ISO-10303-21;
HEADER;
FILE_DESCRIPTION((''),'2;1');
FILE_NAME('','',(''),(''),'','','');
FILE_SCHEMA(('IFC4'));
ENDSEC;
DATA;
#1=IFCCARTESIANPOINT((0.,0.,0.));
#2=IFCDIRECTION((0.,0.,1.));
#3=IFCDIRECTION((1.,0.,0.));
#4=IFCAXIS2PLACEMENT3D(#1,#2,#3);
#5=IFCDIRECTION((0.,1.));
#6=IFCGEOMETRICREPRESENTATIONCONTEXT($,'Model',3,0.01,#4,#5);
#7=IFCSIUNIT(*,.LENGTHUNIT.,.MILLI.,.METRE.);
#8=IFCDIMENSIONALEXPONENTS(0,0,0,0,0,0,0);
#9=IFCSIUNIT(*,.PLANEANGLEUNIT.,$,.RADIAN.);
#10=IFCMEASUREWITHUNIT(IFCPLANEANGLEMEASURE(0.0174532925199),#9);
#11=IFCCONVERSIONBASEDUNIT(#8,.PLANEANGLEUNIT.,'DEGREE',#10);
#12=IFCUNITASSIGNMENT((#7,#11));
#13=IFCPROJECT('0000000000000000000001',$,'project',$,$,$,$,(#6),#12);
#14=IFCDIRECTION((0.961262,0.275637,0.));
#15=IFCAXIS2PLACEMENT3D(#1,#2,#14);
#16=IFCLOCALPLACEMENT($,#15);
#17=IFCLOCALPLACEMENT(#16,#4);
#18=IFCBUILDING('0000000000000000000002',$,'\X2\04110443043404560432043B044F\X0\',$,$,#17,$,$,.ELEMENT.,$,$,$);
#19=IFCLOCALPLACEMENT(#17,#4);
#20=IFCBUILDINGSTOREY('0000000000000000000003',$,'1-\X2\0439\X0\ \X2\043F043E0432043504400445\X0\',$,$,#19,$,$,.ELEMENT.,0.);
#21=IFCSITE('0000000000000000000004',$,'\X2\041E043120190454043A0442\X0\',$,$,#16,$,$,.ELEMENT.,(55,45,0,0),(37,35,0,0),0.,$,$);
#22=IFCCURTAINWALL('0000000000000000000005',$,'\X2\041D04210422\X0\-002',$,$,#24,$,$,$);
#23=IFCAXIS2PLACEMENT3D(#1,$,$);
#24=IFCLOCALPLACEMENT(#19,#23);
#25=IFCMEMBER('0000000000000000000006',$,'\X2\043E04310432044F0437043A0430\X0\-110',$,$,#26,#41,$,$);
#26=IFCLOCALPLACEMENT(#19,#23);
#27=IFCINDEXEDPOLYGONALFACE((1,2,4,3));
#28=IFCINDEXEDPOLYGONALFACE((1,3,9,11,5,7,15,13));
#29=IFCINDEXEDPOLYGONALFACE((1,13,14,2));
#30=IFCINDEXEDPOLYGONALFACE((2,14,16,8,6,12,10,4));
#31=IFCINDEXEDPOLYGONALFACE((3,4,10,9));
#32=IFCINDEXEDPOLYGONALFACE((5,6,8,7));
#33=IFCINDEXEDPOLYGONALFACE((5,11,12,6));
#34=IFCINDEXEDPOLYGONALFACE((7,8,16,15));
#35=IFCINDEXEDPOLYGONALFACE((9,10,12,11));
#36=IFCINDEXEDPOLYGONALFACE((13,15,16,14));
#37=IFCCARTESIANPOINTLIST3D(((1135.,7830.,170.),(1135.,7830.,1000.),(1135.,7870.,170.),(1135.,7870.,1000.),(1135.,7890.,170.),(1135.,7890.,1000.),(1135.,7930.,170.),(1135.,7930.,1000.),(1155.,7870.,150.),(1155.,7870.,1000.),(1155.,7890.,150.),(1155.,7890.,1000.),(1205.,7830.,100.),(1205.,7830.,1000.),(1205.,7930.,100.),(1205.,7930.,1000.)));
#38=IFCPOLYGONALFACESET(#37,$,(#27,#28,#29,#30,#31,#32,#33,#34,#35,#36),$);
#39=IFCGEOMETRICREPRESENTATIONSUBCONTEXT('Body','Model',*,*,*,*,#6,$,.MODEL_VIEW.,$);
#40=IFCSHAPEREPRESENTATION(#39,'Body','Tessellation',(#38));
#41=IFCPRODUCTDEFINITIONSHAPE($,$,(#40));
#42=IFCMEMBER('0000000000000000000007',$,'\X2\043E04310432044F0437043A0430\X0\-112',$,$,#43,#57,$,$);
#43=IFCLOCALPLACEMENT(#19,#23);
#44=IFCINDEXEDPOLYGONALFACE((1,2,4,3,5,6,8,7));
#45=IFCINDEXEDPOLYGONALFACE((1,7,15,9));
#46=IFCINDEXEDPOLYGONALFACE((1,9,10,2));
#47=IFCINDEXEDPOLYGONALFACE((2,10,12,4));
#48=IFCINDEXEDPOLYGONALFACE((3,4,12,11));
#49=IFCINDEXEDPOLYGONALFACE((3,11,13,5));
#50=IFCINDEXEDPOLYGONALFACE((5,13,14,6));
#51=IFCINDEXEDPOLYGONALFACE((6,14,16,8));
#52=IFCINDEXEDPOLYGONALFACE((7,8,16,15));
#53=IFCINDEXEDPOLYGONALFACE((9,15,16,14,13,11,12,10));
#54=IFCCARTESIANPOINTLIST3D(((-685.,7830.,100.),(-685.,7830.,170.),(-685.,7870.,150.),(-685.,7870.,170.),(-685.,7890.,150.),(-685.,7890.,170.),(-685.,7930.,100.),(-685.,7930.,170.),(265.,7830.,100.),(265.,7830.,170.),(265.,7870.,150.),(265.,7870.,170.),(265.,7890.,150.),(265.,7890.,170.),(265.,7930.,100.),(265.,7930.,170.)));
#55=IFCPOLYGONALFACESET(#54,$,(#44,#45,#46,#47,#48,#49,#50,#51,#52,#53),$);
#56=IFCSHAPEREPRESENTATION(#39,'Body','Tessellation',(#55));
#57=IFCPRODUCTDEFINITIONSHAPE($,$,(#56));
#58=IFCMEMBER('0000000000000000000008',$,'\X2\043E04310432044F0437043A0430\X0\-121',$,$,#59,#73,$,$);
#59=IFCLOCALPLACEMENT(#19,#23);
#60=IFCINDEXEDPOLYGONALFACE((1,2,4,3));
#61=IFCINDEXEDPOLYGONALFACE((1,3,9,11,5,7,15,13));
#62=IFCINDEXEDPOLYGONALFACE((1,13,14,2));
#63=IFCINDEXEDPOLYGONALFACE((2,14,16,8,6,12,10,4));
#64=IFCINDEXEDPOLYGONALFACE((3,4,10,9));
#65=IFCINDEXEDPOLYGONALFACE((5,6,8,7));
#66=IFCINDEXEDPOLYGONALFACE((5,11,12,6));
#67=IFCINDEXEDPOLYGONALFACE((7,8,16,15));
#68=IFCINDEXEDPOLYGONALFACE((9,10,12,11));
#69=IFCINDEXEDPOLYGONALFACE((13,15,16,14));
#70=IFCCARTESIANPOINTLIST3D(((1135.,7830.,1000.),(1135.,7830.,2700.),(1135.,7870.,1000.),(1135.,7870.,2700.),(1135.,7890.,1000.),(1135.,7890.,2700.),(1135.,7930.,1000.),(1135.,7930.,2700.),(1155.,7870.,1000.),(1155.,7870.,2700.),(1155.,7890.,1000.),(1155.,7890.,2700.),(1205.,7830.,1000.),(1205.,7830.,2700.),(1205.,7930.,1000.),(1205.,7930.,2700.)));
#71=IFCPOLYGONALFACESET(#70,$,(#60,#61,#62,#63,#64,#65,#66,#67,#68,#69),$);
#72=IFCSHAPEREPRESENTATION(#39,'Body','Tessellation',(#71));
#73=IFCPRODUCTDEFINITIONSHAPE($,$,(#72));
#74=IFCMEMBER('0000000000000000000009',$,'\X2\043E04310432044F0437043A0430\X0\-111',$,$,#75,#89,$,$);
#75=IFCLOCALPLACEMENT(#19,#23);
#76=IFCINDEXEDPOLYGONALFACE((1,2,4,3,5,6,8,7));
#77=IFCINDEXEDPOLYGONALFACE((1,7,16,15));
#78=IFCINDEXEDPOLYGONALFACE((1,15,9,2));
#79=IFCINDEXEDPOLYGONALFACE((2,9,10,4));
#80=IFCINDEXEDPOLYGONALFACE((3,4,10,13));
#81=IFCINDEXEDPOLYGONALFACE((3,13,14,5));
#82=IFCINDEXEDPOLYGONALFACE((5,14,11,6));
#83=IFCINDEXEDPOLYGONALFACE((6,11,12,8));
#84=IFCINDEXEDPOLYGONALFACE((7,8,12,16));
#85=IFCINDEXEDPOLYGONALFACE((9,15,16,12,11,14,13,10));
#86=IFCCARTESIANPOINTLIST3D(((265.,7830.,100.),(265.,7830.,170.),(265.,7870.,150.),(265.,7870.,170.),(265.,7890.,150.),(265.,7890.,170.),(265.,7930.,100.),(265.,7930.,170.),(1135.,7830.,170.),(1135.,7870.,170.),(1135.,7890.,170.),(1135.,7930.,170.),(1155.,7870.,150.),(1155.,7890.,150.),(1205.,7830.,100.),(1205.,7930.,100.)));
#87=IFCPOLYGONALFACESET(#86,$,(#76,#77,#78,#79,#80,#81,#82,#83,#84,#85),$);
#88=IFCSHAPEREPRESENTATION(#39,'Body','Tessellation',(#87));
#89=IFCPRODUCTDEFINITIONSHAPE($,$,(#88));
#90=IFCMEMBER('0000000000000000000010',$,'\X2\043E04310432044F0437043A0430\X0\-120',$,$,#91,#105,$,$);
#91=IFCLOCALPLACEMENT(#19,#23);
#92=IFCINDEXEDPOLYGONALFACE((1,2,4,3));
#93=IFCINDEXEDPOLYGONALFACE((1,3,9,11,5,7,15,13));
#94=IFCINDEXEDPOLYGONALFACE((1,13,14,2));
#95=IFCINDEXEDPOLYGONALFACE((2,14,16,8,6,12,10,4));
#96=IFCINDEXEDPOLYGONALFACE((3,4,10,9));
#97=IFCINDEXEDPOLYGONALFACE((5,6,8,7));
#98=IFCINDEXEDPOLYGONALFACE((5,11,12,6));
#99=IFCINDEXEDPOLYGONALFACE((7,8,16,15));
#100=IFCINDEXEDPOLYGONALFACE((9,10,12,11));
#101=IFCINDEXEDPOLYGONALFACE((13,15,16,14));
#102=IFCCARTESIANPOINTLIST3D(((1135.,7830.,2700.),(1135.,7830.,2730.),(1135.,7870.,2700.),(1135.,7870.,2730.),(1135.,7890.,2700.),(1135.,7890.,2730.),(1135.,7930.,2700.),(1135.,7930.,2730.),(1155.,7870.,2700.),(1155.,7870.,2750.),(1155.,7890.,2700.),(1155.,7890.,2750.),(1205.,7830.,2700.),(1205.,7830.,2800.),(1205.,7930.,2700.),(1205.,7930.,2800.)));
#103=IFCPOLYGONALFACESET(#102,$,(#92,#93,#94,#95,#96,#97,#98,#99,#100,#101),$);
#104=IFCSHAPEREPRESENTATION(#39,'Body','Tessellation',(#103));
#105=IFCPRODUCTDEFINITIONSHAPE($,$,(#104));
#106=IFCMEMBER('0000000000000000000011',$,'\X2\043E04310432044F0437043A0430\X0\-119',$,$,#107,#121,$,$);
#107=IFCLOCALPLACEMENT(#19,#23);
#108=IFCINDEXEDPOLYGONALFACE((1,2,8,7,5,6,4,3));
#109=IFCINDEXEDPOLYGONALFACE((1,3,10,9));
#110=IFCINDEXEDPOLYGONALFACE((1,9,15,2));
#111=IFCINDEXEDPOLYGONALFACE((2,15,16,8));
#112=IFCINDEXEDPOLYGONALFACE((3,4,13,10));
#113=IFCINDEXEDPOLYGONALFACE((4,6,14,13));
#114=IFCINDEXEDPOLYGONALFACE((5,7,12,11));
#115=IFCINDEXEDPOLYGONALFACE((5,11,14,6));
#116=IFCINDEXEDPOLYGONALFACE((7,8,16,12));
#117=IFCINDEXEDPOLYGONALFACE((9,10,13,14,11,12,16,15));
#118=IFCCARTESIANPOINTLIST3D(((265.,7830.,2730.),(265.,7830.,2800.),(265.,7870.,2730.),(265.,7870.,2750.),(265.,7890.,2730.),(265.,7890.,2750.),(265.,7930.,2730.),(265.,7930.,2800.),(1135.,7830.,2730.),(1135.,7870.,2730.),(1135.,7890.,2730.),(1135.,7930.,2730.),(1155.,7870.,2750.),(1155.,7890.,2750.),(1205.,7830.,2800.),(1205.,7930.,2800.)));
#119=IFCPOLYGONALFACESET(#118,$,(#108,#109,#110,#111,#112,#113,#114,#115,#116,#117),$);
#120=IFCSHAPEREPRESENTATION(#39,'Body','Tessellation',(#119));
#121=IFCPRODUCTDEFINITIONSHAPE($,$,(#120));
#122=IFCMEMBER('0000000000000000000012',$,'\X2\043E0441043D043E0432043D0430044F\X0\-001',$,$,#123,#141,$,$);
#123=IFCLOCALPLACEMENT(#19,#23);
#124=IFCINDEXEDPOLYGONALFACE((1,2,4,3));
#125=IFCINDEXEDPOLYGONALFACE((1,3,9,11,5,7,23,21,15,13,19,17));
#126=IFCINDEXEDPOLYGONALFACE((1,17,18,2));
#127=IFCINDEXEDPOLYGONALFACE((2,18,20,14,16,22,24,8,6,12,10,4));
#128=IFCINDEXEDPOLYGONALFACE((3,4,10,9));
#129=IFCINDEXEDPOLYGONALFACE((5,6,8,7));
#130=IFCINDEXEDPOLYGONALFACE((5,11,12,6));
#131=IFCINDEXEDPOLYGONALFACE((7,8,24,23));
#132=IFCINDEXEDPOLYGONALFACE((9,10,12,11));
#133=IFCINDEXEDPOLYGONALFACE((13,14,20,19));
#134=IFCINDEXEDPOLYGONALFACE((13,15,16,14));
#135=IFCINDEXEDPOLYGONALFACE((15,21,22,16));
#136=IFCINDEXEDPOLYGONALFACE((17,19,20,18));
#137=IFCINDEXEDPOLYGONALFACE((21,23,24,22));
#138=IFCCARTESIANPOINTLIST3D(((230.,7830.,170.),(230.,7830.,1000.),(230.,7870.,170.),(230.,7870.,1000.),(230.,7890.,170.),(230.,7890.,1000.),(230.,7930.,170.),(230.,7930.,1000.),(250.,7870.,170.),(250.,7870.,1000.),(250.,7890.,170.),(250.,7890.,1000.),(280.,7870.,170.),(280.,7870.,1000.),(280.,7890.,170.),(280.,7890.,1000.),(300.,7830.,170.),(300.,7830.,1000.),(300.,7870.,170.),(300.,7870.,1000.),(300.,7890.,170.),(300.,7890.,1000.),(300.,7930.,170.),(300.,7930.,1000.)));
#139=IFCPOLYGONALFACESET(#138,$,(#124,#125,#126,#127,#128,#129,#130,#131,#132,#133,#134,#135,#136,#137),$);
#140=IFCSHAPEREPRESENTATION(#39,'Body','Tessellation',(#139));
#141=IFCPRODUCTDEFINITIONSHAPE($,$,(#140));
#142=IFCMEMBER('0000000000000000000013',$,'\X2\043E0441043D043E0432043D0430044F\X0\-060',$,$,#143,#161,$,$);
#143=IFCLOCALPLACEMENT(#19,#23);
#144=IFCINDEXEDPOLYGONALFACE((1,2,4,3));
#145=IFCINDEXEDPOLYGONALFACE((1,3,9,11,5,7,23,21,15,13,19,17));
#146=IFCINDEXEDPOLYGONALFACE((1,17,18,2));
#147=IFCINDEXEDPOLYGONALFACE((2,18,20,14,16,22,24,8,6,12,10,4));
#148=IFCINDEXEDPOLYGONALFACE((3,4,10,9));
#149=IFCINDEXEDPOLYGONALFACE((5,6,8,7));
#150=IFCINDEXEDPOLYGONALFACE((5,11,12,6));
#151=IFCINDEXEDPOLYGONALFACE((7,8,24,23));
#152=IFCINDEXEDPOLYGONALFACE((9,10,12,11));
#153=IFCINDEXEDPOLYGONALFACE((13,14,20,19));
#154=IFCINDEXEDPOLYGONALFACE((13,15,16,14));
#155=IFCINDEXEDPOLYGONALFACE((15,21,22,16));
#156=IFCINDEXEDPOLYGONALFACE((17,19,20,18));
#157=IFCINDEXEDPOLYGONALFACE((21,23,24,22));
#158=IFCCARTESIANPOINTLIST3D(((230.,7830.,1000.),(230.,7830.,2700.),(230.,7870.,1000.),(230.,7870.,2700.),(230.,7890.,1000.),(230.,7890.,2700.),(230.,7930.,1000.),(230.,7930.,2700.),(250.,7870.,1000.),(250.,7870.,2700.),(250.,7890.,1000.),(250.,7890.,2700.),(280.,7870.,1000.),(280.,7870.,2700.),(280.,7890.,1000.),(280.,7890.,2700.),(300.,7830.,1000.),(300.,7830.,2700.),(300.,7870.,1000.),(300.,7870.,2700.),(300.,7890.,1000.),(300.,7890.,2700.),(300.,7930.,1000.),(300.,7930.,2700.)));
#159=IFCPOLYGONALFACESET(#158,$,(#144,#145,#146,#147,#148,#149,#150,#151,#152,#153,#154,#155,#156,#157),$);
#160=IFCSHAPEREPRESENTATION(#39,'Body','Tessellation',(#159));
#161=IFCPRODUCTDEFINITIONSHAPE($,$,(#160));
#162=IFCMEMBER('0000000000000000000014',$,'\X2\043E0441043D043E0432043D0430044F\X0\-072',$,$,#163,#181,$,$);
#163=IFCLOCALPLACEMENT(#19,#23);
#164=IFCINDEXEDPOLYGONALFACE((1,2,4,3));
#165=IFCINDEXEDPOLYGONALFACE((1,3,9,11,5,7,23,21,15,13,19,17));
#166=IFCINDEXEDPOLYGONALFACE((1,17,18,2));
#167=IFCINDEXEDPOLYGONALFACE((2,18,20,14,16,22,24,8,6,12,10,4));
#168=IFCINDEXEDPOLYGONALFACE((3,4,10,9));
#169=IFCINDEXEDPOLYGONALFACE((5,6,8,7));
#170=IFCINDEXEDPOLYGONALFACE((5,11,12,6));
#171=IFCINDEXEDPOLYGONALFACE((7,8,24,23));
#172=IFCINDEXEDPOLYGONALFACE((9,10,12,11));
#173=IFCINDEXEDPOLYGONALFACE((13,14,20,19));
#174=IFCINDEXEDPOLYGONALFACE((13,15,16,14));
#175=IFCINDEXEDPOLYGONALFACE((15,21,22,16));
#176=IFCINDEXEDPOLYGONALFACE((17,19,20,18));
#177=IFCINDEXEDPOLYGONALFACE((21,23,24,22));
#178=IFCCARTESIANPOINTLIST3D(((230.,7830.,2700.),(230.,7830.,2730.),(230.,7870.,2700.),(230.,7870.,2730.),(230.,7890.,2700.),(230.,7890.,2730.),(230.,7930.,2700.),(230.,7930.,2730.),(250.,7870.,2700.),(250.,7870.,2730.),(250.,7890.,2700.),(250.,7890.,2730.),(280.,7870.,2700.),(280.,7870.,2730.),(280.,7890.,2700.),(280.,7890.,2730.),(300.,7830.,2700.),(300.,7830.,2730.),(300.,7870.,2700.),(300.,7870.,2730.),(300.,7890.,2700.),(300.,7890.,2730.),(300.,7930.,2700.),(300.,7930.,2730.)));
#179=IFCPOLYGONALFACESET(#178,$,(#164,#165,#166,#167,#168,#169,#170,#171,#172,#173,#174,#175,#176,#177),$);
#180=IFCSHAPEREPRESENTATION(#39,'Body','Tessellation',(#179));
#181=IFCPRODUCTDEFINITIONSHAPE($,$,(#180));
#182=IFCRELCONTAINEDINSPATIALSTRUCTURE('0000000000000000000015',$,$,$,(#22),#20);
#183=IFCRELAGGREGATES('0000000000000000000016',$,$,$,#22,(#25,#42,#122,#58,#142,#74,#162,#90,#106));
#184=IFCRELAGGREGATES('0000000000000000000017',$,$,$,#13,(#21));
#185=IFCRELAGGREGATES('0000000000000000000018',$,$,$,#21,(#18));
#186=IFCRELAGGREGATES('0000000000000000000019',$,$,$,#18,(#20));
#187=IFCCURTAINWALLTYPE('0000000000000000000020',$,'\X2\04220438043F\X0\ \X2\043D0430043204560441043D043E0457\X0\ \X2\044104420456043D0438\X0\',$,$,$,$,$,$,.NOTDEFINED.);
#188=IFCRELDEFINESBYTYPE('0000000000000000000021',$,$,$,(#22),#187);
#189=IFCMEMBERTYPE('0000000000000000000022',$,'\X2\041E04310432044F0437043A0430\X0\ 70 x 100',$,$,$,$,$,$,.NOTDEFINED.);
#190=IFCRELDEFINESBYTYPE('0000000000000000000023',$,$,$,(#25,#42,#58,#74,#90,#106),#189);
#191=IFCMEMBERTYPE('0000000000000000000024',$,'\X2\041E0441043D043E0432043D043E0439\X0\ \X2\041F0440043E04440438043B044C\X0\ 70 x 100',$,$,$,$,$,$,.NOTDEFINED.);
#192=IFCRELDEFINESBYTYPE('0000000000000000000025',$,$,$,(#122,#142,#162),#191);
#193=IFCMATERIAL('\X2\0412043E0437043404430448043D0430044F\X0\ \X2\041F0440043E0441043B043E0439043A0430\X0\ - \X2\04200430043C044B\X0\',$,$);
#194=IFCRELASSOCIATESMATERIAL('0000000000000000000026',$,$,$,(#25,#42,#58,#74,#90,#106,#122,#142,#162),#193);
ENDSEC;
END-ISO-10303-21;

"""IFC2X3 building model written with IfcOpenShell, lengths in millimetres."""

from ifc_helpers import new_model, entity, si_unit, converted_unit, direction, frame, origin_with_axes, place, context, subcontext, project, spatial, polyline, outline, extrude, clip, halfspace, material, type_object, element, aggregate, save


model = new_model("IFC2X3")

# Units and contexts
model_context = context("Model", 3, precision=0.01, world=origin_with_axes(), true_north=direction((0.0, 1.0)))
body_context = subcontext(model_context, "Body", "Model", "MODEL_VIEW")
ifc_project = project(units=[si_unit("LENGTHUNIT", "METRE", prefix="MILLI"), converted_unit("PLANEANGLEUNIT", "DEGREE", entity("IfcPlaneAngleMeasure", 0.0174532925199), si_unit("PLANEANGLEUNIT", "RADIAN"), dimensions=[0, 0, 0, 0, 0, 0, 0])], contexts=[model_context])

# Site, building, storey
site_placement = place(None, frame((0.0, 0.0, 0.0), z_axis=(0.0, 0.0, 1.0), x_axis=(0.961262, 0.275637, 0.0)))
site = spatial("IfcSite", under=ifc_project, at=site_placement, Name="Об’єкт", CompositionType="ELEMENT", RefLatitude=(55, 45, 0, 0), RefLongitude=(37, 35, 0, 0), RefElevation=0.0)
building_placement = place(site_placement, origin_with_axes())
building = spatial("IfcBuilding", under=site, at=building_placement, Name="Будівля", CompositionType="ELEMENT")
storey_placement = place(building_placement, origin_with_axes())
storey = spatial("IfcBuildingStorey", under=building, at=storey_placement, Name="1-й поверх", CompositionType="ELEMENT", Elevation=0.0)

# Curtain wall, members
curtain_wall_type = type_object("IfcCurtainWallType", Name="Тип навісної стіни", PredefinedType="NOTDEFINED")
curtain_wall_placement = place(storey_placement, frame((-210.0, 7880.0, 100.0), z_axis=(0.0, 0.0, 1.0), x_axis=(1.0, 0.0, 0.0)))
curtain_wall = element("IfcCurtainWall", 1, at=curtain_wall_placement, inside=storey, type_object=curtain_wall_type, Name="НСТ-002")
ifc_material_1 = material(Name="Воздушная Прослойка - Рамы")
member_type_1 = type_object("IfcMemberType", Name="Обвязка 70 x 100", PredefinedType="NOTDEFINED")
member_1_placement = place(curtain_wall_placement, frame((1415.0, 0.0, 900.0), z_axis=(0.0, 0.0, -1.0), x_axis=(-1.0, 0.0, 0.0)))
member_1 = element("IfcMember", 2, at=member_1_placement, type_object=member_type_1, material=ifc_material_1, Name="обвязка-110", context=body_context, shape_type="Clipping", body=[
    clip(extrude(outline(polyline([(-50.0, 10.0), (-50.0, -10.0), (-70.0, -10.0), (-70.0, -50.0), (0.0, -50.0), (0.0, 50.0), (-70.0, 50.0), (-70.0, 10.0), (-50.0, 10.0)])), frame((0.0, 0.0, 0.0), z_axis=(0.0, 0.0, 1.0), x_axis=(-1.0, 0.0, 0.0)), (0.0, 0.0, 1.0), 900.0), halfspace(frame((450.0, 0.0, 450.0), z_axis=(-0.707107, 0.0, -0.707107), x_axis=(0.0, 1.0, 0.0)), True)),
])
member_2_placement = place(curtain_wall_placement, frame((475.0, 0.0, 0.0), z_axis=(-1.0, 0.0, 0.0), x_axis=(0.0, 0.0, 1.0)))
member_2 = element("IfcMember", 3, at=member_2_placement, type_object=member_type_1, material=ifc_material_1, Name="обвязка-112", context=body_context, shape_type="SweptSolid", body=[
    extrude(outline(polyline([(-10.0, -50.0), (10.0, -50.0), (10.0, -70.0), (50.0, -70.0), (50.0, 0.0), (-50.0, 0.0), (-50.0, -70.0), (-10.0, -70.0), (-10.0, -50.0)])), frame((0.0, 0.0, 0.0), z_axis=(0.0, 0.0, 1.0), x_axis=(0.0, 1.0, 0.0)), (0.0, 0.0, 1.0), 950.0),
])
member_3_placement = place(curtain_wall_placement, frame((1415.0, 0.0, 2600.0), z_axis=(0.0, 0.0, -1.0), x_axis=(-1.0, 0.0, 0.0)))
member_3 = element("IfcMember", 4, at=member_3_placement, type_object=member_type_1, material=ifc_material_1, Name="обвязка-121", context=body_context, shape_type="SweptSolid", body=[
    extrude(outline(polyline([(-50.0, 10.0), (-50.0, -10.0), (-70.0, -10.0), (-70.0, -50.0), (0.0, -50.0), (0.0, 50.0), (-70.0, 50.0), (-70.0, 10.0), (-50.0, 10.0)])), frame((0.0, 0.0, 0.0), z_axis=(0.0, 0.0, 1.0), x_axis=(-1.0, 0.0, 0.0)), (0.0, 0.0, 1.0), 1700.0),
])
member_4_placement = place(curtain_wall_placement, frame((1415.0, 0.0, 0.0), z_axis=(-1.0, 0.0, 0.0), x_axis=(0.0, 0.0, 1.0)))
member_4 = element("IfcMember", 5, at=member_4_placement, type_object=member_type_1, material=ifc_material_1, Name="обвязка-111", context=body_context, shape_type="Clipping", body=[
    clip(extrude(outline(polyline([(-10.0, -50.0), (10.0, -50.0), (10.0, -70.0), (50.0, -70.0), (50.0, 0.0), (-50.0, 0.0), (-50.0, -70.0), (-10.0, -70.0), (-10.0, -50.0)])), frame((0.0, 0.0, 0.0), z_axis=(0.0, 0.0, 1.0), x_axis=(0.0, 1.0, 0.0)), (0.0, 0.0, 1.0), 940.0), halfspace(frame((0.0, 0.0, 0.0), z_axis=(-0.707107, 0.0, 0.707107), x_axis=(0.0, -1.0, 0.0)), True)),
])
member_5_placement = place(curtain_wall_placement, frame((1415.0, 0.0, 2700.0), z_axis=(0.0, 0.0, -1.0), x_axis=(-1.0, 0.0, 0.0)))
member_5 = element("IfcMember", 6, at=member_5_placement, type_object=member_type_1, material=ifc_material_1, Name="обвязка-120", context=body_context, shape_type="Clipping", body=[
    clip(extrude(outline(polyline([(-50.0, 10.0), (-50.0, -10.0), (-70.0, -10.0), (-70.0, -50.0), (0.0, -50.0), (0.0, 50.0), (-70.0, 50.0), (-70.0, 10.0), (-50.0, 10.0)])), frame((0.0, 0.0, 0.0), z_axis=(0.0, 0.0, 1.0), x_axis=(-1.0, 0.0, 0.0)), (0.0, 0.0, 1.0), 100.0), halfspace(frame((0.0, 0.0, 0.0), z_axis=(-0.707107, 0.0, 0.707107), x_axis=(0.0, -1.0, 0.0)), True)),
])
member_6_placement = place(curtain_wall_placement, frame((475.0, 0.0, 2700.0), z_axis=(1.0, 0.0, 0.0), x_axis=(0.0, 0.0, -1.0)))
member_6 = element("IfcMember", 7, at=member_6_placement, type_object=member_type_1, material=ifc_material_1, Name="обвязка-119", context=body_context, shape_type="Clipping", body=[
    clip(extrude(outline(polyline([(10.0, 50.0), (-10.0, 50.0), (-10.0, 70.0), (-50.0, 70.0), (-50.0, 0.0), (50.0, 0.0), (50.0, 70.0), (10.0, 70.0), (10.0, 50.0)])), frame((0.0, 0.0, 0.0), z_axis=(0.0, 0.0, 1.0), x_axis=(0.0, -1.0, 0.0)), (0.0, 0.0, 1.0), 940.0), halfspace(frame((470.0, 0.0, 470.0), z_axis=(-0.707107, 0.0, -0.707107), x_axis=(0.0, 1.0, 0.0)), True)),
])
member_type_2 = type_object("IfcMemberType", Name="Основной Профиль 70 x 100", PredefinedType="NOTDEFINED")
member_7_placement = place(curtain_wall_placement, frame((475.0, 0.0, 0.0), z_axis=(0.0, 0.0, 1.0), x_axis=(1.0, 0.0, 0.0)))
member_7 = element("IfcMember", 8, at=member_7_placement, type_object=member_type_2, material=ifc_material_1, Name="основная-001", context=body_context, shape_type="SweptSolid", body=[
    extrude(outline(polyline([(-15.0, -10.0), (-35.0, -10.0), (-35.0, -50.0), (35.0, -50.0), (35.0, -10.0), (15.0, -10.0), (15.0, 10.0), (35.0, 10.0), (35.0, 50.0), (-35.0, 50.0), (-35.0, 10.0), (-15.0, 10.0), (-15.0, -10.0)])), frame((0.0, 0.0, 70.0), z_axis=(0.0, 0.0, 1.0), x_axis=(1.0, 0.0, 0.0)), (0.0, 0.0, 1.0), 830.0),
])
member_8_placement = place(curtain_wall_placement, frame((475.0, 0.0, 900.0), z_axis=(0.0, 0.0, 1.0), x_axis=(1.0, 0.0, 0.0)))
member_8 = element("IfcMember", 9, at=member_8_placement, type_object=member_type_2, material=ifc_material_1, Name="основная-060", context=body_context, shape_type="SweptSolid", body=[
    extrude(outline(polyline([(-15.0, -10.0), (-35.0, -10.0), (-35.0, -50.0), (35.0, -50.0), (35.0, -10.0), (15.0, -10.0), (15.0, 10.0), (35.0, 10.0), (35.0, 50.0), (-35.0, 50.0), (-35.0, 10.0), (-15.0, 10.0), (-15.0, -10.0)])), origin_with_axes(), (0.0, 0.0, 1.0), 1700.0),
])
member_9_placement = place(curtain_wall_placement, frame((475.0, 0.0, 2600.0), z_axis=(0.0, 0.0, 1.0), x_axis=(1.0, 0.0, 0.0)))
member_9 = element("IfcMember", 10, at=member_9_placement, type_object=member_type_2, material=ifc_material_1, Name="основная-072", context=body_context, shape_type="SweptSolid", body=[
    extrude(outline(polyline([(-15.0, -10.0), (-35.0, -10.0), (-35.0, -50.0), (35.0, -50.0), (35.0, -10.0), (15.0, -10.0), (15.0, 10.0), (35.0, 10.0), (35.0, 50.0), (-35.0, 50.0), (-35.0, 10.0), (-15.0, 10.0), (-15.0, -10.0)])), origin_with_axes(), (0.0, 0.0, 1.0), 30.0),
])

aggregate(curtain_wall, [member_1, member_2, member_7, member_3, member_8, member_4, member_9, member_5, member_6])

save(model, "model.ifc")
